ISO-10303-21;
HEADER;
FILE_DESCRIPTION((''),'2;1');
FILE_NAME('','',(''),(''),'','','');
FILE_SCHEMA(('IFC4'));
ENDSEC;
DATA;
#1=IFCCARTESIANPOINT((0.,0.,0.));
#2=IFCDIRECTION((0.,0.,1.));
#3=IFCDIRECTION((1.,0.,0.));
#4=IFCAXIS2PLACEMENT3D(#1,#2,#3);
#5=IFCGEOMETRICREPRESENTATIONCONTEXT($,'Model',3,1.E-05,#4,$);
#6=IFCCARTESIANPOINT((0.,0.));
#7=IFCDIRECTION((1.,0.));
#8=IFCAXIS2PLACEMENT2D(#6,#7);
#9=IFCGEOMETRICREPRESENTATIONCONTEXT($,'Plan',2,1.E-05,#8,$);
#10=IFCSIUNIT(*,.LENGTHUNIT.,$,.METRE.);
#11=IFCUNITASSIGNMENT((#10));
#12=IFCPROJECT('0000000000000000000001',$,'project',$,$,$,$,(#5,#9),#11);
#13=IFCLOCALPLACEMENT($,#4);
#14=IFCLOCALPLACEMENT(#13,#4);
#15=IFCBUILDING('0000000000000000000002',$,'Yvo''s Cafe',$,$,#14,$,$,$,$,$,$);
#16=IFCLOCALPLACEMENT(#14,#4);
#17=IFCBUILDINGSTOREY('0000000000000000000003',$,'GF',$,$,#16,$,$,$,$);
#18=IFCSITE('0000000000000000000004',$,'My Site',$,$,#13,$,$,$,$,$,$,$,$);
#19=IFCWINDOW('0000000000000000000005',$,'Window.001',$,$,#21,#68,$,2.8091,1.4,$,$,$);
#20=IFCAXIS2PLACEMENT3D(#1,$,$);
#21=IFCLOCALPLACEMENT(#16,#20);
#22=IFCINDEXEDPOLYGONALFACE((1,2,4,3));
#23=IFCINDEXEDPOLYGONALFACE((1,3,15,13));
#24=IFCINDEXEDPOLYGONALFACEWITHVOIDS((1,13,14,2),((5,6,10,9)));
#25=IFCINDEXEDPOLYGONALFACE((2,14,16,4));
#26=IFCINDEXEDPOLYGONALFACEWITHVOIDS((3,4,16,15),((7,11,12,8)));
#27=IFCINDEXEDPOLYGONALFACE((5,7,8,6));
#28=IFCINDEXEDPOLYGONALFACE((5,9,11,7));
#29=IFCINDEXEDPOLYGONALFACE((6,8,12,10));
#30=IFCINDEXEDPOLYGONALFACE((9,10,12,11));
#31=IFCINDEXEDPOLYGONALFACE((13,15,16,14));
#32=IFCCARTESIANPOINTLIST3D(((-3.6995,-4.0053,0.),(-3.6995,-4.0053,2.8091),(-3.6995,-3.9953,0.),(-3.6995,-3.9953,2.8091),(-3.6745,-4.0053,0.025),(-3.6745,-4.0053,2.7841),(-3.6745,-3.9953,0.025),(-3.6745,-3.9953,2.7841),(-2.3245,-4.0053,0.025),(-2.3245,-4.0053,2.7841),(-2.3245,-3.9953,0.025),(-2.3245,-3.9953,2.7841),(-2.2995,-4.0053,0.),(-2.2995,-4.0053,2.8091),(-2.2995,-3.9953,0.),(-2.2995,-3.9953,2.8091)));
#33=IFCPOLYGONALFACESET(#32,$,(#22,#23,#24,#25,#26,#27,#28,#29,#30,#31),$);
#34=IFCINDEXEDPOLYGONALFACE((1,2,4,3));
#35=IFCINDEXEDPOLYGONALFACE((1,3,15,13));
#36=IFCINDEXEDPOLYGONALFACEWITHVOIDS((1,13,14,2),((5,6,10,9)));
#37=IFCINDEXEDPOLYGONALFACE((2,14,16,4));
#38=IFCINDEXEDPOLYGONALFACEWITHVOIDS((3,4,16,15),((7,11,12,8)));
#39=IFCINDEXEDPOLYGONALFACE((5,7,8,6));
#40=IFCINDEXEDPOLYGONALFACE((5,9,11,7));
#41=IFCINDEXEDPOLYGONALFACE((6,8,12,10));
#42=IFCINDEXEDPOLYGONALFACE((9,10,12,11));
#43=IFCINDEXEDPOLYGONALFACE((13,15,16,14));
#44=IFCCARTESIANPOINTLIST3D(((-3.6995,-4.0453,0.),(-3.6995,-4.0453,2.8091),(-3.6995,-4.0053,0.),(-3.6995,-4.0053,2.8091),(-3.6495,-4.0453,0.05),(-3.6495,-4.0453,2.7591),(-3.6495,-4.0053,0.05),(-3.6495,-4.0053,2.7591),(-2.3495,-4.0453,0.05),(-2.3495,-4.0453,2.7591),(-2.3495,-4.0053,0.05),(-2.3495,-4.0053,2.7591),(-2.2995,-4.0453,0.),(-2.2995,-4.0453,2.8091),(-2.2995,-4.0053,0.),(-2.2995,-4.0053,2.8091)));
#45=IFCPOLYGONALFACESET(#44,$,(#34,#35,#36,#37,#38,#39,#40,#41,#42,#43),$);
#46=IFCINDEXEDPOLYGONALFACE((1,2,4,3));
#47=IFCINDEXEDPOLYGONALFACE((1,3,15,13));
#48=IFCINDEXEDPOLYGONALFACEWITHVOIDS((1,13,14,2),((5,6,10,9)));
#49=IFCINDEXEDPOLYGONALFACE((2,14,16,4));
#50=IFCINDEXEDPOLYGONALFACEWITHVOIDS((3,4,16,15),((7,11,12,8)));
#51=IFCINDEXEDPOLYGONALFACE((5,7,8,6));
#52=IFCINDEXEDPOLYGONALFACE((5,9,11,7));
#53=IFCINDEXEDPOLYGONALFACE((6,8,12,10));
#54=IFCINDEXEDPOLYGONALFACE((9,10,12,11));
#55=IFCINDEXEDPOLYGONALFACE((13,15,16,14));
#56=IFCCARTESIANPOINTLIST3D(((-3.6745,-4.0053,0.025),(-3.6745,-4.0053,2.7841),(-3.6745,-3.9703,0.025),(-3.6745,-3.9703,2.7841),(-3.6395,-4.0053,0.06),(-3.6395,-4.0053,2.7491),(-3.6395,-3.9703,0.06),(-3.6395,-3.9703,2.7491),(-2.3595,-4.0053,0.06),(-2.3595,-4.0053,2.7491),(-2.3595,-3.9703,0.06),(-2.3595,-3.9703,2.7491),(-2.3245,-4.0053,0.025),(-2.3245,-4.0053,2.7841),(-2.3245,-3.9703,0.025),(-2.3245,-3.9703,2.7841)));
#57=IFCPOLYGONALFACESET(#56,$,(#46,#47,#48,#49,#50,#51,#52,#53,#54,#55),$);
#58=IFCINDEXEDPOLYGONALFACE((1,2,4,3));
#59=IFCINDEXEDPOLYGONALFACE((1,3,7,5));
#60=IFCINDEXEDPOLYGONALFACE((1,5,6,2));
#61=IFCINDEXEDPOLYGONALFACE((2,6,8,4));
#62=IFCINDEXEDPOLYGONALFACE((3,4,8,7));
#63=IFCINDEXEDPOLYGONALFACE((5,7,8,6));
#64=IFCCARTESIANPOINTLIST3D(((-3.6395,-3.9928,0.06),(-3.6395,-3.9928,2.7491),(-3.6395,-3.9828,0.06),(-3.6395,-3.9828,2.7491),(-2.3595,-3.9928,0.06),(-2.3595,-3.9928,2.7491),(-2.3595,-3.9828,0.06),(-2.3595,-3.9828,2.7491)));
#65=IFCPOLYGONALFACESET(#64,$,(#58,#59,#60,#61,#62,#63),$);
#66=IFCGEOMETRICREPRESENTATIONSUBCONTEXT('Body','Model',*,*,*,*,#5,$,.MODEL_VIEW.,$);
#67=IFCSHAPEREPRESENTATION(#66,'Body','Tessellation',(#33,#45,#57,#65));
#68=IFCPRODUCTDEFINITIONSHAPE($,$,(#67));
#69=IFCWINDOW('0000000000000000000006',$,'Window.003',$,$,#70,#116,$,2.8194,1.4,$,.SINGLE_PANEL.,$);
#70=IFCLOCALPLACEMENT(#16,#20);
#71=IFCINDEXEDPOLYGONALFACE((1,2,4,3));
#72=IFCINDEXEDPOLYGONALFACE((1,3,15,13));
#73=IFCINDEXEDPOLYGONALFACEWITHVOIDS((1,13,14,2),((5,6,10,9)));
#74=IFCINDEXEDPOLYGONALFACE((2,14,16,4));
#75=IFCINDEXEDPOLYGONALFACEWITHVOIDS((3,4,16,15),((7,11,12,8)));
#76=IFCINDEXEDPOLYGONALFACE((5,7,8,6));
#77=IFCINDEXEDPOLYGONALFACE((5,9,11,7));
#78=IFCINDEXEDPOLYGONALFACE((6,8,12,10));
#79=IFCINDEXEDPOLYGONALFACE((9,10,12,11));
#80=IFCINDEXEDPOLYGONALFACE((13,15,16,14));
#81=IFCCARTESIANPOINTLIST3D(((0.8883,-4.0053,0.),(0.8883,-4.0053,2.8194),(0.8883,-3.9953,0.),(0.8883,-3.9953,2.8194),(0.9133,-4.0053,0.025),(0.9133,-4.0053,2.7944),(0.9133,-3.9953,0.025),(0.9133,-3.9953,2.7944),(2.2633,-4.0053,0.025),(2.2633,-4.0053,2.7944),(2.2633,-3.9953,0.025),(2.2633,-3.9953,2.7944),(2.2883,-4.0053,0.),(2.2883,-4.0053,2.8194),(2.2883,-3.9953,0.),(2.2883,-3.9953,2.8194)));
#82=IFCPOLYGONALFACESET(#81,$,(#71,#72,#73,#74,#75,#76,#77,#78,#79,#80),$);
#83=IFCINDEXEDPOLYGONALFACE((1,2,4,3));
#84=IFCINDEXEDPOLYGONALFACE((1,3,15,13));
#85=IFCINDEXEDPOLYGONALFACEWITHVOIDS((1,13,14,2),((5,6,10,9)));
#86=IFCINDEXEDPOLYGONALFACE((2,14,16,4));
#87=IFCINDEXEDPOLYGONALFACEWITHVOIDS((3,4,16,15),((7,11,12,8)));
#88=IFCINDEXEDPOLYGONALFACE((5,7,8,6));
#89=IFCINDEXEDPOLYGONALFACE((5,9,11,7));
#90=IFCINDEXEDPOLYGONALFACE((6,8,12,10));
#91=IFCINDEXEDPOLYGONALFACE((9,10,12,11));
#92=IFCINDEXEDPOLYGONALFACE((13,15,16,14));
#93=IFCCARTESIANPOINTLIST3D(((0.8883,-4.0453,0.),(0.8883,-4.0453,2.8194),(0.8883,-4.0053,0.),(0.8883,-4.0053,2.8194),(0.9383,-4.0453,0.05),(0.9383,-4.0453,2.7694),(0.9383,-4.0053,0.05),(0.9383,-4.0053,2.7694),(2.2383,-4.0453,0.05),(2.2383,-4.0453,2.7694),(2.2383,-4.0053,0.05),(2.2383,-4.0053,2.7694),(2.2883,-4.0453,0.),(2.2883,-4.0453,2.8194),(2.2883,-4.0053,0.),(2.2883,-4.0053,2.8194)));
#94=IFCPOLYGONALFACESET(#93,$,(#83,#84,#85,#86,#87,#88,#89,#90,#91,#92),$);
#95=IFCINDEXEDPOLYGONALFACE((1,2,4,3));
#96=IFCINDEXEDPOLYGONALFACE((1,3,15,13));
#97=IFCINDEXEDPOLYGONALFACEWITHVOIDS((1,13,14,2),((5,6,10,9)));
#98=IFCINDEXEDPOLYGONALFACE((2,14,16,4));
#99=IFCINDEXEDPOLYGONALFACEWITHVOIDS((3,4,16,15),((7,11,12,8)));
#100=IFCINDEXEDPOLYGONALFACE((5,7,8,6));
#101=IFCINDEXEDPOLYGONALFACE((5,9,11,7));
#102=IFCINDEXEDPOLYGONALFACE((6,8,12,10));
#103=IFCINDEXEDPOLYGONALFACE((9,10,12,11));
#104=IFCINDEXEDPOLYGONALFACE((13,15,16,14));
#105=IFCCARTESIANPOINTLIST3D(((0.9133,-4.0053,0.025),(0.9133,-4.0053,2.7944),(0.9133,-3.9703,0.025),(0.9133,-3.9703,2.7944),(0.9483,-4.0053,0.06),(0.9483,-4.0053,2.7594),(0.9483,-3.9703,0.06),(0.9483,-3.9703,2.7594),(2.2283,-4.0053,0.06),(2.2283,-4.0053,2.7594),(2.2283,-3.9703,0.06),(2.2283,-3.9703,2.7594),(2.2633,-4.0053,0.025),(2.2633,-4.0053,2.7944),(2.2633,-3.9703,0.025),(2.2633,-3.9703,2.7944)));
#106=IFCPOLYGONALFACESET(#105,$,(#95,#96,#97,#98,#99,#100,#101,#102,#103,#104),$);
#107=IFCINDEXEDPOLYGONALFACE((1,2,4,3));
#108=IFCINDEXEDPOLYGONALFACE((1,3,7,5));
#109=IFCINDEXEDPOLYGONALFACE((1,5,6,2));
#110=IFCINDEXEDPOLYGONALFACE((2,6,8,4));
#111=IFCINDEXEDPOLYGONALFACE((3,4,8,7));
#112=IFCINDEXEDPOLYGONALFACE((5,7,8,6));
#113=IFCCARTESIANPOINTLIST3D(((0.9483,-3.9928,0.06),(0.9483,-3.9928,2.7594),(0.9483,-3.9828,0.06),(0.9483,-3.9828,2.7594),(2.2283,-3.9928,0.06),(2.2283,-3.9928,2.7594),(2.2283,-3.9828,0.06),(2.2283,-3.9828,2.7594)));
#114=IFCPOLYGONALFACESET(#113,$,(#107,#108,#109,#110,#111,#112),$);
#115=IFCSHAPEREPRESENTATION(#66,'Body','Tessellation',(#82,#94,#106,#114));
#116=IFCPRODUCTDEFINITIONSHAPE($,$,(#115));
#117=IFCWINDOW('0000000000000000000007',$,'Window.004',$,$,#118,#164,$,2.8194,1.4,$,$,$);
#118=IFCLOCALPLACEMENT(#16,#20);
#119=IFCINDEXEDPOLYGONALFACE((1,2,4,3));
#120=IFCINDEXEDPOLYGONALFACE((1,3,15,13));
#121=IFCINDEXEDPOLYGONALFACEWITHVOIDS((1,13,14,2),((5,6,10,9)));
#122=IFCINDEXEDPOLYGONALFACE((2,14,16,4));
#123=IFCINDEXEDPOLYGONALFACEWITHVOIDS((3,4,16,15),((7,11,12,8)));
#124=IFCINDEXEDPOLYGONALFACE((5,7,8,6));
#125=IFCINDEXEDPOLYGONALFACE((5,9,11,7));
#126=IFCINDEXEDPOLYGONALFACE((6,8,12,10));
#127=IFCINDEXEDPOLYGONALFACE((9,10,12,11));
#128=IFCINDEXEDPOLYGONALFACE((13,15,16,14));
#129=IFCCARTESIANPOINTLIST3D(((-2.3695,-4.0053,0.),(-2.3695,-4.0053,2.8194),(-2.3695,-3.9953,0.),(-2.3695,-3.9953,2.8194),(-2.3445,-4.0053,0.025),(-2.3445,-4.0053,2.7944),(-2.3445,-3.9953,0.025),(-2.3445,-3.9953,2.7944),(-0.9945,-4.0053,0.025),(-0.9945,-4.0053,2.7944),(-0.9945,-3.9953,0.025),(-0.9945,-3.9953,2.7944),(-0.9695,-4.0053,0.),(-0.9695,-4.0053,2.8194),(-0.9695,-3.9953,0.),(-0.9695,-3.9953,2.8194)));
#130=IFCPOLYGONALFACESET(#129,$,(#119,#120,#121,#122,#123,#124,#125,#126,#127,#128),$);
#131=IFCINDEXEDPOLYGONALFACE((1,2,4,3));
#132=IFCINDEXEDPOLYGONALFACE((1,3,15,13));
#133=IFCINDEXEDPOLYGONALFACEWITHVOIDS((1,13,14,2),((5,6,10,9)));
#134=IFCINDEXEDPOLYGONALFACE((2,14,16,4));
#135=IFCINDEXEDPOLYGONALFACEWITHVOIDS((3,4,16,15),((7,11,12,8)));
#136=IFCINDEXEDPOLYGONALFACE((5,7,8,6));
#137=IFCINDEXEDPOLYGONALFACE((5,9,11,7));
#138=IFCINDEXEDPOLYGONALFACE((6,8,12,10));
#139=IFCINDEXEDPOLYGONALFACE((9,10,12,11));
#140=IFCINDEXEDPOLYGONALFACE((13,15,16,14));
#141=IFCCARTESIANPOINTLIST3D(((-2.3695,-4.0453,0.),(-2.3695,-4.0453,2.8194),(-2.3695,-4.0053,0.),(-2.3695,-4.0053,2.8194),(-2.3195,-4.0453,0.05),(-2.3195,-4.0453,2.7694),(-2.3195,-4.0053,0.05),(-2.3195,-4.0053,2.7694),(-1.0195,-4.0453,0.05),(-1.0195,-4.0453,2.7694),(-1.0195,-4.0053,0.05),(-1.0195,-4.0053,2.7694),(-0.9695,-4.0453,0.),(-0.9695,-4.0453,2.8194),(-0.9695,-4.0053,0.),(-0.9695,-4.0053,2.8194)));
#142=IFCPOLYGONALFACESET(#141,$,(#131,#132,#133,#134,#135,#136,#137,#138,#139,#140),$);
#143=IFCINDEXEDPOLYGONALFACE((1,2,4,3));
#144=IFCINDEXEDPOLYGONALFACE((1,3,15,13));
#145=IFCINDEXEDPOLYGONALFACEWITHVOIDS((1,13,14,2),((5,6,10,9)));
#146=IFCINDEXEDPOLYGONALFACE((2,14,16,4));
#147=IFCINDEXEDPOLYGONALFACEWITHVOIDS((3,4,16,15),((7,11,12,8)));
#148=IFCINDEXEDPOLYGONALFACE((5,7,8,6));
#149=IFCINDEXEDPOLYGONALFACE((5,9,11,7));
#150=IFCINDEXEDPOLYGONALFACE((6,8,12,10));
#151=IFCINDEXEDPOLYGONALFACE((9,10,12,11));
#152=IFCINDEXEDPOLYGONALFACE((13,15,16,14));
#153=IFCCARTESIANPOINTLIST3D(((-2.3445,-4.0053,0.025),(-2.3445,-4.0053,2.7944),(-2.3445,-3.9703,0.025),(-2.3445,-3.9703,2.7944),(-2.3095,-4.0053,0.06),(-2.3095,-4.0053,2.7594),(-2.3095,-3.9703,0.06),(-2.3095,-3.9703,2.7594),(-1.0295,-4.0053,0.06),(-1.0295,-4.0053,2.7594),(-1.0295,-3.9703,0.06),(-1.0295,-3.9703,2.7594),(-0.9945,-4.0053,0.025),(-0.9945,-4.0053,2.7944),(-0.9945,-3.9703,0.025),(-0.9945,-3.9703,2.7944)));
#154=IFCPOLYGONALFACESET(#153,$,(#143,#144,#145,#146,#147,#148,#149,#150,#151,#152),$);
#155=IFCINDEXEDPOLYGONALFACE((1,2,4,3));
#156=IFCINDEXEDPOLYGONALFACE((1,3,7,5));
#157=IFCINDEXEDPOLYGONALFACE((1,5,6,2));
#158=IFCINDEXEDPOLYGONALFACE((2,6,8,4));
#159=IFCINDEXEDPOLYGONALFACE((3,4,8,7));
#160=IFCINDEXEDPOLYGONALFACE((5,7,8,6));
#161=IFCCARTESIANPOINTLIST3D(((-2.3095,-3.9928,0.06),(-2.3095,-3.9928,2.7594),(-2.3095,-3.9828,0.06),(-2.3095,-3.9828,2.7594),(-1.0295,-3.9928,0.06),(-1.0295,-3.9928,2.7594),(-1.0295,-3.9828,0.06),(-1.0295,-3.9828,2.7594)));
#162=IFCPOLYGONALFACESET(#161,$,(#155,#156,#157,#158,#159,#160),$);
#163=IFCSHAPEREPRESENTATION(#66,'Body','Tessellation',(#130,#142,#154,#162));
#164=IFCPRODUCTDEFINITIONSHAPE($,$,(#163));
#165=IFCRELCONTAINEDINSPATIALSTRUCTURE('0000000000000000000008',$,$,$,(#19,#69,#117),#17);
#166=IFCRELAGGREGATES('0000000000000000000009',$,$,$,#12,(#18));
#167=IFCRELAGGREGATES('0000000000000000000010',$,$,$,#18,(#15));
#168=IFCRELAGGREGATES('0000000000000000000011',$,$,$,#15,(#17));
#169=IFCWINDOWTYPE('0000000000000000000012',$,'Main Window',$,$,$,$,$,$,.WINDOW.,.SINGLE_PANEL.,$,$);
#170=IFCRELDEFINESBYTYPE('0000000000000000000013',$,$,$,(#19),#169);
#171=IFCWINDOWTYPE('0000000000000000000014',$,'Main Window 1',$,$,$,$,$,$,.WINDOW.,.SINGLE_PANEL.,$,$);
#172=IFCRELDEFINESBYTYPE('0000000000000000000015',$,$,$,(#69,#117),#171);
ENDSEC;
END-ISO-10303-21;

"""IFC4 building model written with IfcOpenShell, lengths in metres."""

from ifc_helpers import new_model, entity, si_unit, frame, origin_with_axes, origin_2d_with_axis, place, context, subcontext, project, spatial, line, indexed_curve, outline, extrude, shape, source, transform, mapped, type_object, type_shapes, element, save


model = new_model("IFC4")

# Units and contexts
model_context = context("Model", 3, precision=1e-05, world=origin_with_axes())
plan_context = context("Plan", 2, precision=1e-05, world=origin_2d_with_axis())
body_context_1 = subcontext(model_context, "Body", "Model", "MODEL_VIEW")
body_context_2 = subcontext(plan_context, "Body", "Plan", "PLAN_VIEW")
ifc_project = project(units=[si_unit("LENGTHUNIT", "METRE")], contexts=[model_context, plan_context])

# Site, building, storey
site_placement = place(None, origin_with_axes())
site = spatial("IfcSite", under=ifc_project, at=site_placement, Name="My Site")
building_placement = place(site_placement, origin_with_axes())
building = spatial("IfcBuilding", under=site, at=building_placement, Name="Yvo's Cafe")
storey_placement = place(building_placement, origin_with_axes())
storey = spatial("IfcBuildingStorey", under=building, at=storey_placement, Name="GF")

# Windows
window_type_1 = type_object("IfcWindowType", Name="Main Window", PartitioningType="SINGLE_PANEL", PredefinedType="WINDOW")
shared_shape_1 = source(origin_with_axes(), body_context_1, "Body", "SweptSolid", [
    extrude(outline(indexed_curve([(0.0, 0.0), (1.4, 0.0), (1.4, 2.8091), (0.0, 2.8091)], segments=[line(1, 2, 3, 4, 1)]), holes=[indexed_curve([(0.025, 0.025), (1.375, 0.025), (1.375, 2.7841), (0.025, 2.7841)], segments=[line(1, 2, 3, 4, 1)])]), frame((0.0, 0.09, 0.0), z_axis=(0.0, -1.0, 0.0), x_axis=(1.0, 0.0, 0.0)), (0.0, 0.0, -1.0), 0.01),
    extrude(outline(indexed_curve([(0.0, 0.0), (1.4, 0.0), (1.4, 2.8091), (0.0, 2.8091)], segments=[line(1, 2, 3, 4, 1)]), holes=[indexed_curve([(0.05, 0.05), (1.35, 0.05), (1.35, 2.7591), (0.05, 2.7591)], segments=[line(1, 2, 3, 4, 1)])]), frame((0.0, 0.05, 0.0), z_axis=(0.0, -1.0, 0.0), x_axis=(1.0, 0.0, 0.0)), (0.0, 0.0, -1.0), 0.04),
    extrude(outline(indexed_curve([(0.0, 0.0), (1.35, 0.0), (1.35, 2.7591), (0.0, 2.7591)], segments=[line(1, 2, 3, 4, 1)]), holes=[indexed_curve([(0.035, 0.035), (1.315, 0.035), (1.315, 2.7241), (0.035, 2.7241)], segments=[line(1, 2, 3, 4, 1)])]), frame((0.025, 0.09, 0.025), z_axis=(0.0, -1.0, 0.0), x_axis=(1.0, 0.0, 0.0)), (0.0, 0.0, -1.0), 0.035),
    extrude(outline(indexed_curve([(0.035, 0.035), (1.315, 0.035), (1.315, 2.7241), (0.035, 2.7241)], segments=[line(1, 2, 3, 4, 1)])), frame((0.025, 0.1025, 0.025), z_axis=(0.0, -1.0, 0.0), x_axis=(1.0, 0.0, 0.0)), (0.0, 0.0, -1.0), 0.01),
])
shared_shape_2 = source(origin_with_axes(), body_context_2, "Body", "Curve2D", [
    entity("IfcIndexedPolyCurve", entity("IfcCartesianPointList2D", [[0.05, 0.05], [1.35, 0.05]])),
    entity("IfcIndexedPolyCurve", entity("IfcCartesianPointList2D", [[0.0, 0.1], [0.025, 0.1], [0.025, 0.09], [0.05, 0.09], [0.05, 0.05], [0.0, 0.05]]), [entity("IfcLineIndex", [1, 2, 3, 4, 5, 6, 1])]),
    entity("IfcIndexedPolyCurve", entity("IfcCartesianPointList2D", [[1.4, 0.1], [1.375, 0.1], [1.375, 0.09], [1.35, 0.09], [1.35, 0.05], [1.4, 0.05]]), [entity("IfcLineIndex", [1, 2, 3, 4, 5, 6, 1])]),
    entity("IfcIndexedPolyCurve", entity("IfcCartesianPointList2D", [[0.025, 0.09], [0.06, 0.09], [0.06, 0.125], [0.025, 0.125]]), [entity("IfcLineIndex", [1, 2, 3, 4, 1])]),
    entity("IfcIndexedPolyCurve", entity("IfcCartesianPointList2D", [[1.375, 0.09], [1.34, 0.09], [1.34, 0.125], [1.375, 0.125]]), [entity("IfcLineIndex", [1, 2, 3, 4, 1])]),
    entity("IfcIndexedPolyCurve", entity("IfcCartesianPointList2D", [[0.06, 0.09], [1.34, 0.09]])),
    entity("IfcIndexedPolyCurve", entity("IfcCartesianPointList2D", [[0.06, 0.125], [1.34, 0.125]])),
    entity("IfcIndexedPolyCurve", entity("IfcCartesianPointList2D", [[0.06, 0.1075], [1.34, 0.1075]])),
])
type_shapes(window_type_1, [shared_shape_1, shared_shape_2])
window_1_placement = place(storey_placement, frame((-3.6995, -4.0953, 0.0), z_axis=(0.0, 0.0, 1.0), x_axis=(1.0, 0.0, 0.0)))
element("IfcWindow", 1, at=window_1_placement, inside=storey, type_object=window_type_1, Name="Window.001", OverallHeight=2.8091, OverallWidth=1.4, shapes=[
    shape(body_context_1, "Body", "MappedRepresentation", [mapped(shared_shape_1, transform((0.0, 0.0, 0.0), x_axis=(1.0, 0.0, 0.0), y_axis=(0.0, 1.0, 0.0), z_axis=(0.0, 0.0, 1.0), scale=1.0))]),
    shape(body_context_2, "Body", "MappedRepresentation", [mapped(shared_shape_2, transform((0.0, 0.0, 0.0), x_axis=(1.0, 0.0, 0.0), y_axis=(0.0, 1.0, 0.0), z_axis=(0.0, 0.0, 1.0), scale=1.0))]),
])
window_type_2 = type_object("IfcWindowType", Name="Main Window 1", PartitioningType="SINGLE_PANEL", PredefinedType="WINDOW")
shared_shape_3 = source(origin_with_axes(), body_context_1, "Body", "SweptSolid", [
    extrude(outline(indexed_curve([(0.0, 0.0), (1.4, 0.0), (1.4, 2.8194), (0.0, 2.8194)], segments=[line(1, 2, 3, 4, 1)]), holes=[indexed_curve([(0.025, 0.025), (1.375, 0.025), (1.375, 2.7944), (0.025, 2.7944)], segments=[line(1, 2, 3, 4, 1)])]), frame((0.0, 0.09, 0.0), z_axis=(0.0, -1.0, 0.0), x_axis=(1.0, 0.0, 0.0)), (0.0, 0.0, -1.0), 0.01),
    extrude(outline(indexed_curve([(0.0, 0.0), (1.4, 0.0), (1.4, 2.8194), (0.0, 2.8194)], segments=[line(1, 2, 3, 4, 1)]), holes=[indexed_curve([(0.05, 0.05), (1.35, 0.05), (1.35, 2.7694), (0.05, 2.7694)], segments=[line(1, 2, 3, 4, 1)])]), frame((0.0, 0.05, 0.0), z_axis=(0.0, -1.0, 0.0), x_axis=(1.0, 0.0, 0.0)), (0.0, 0.0, -1.0), 0.04),
    extrude(outline(indexed_curve([(0.0, 0.0), (1.35, 0.0), (1.35, 2.7694), (0.0, 2.7694)], segments=[line(1, 2, 3, 4, 1)]), holes=[indexed_curve([(0.035, 0.035), (1.315, 0.035), (1.315, 2.7344), (0.035, 2.7344)], segments=[line(1, 2, 3, 4, 1)])]), frame((0.025, 0.09, 0.025), z_axis=(0.0, -1.0, 0.0), x_axis=(1.0, 0.0, 0.0)), (0.0, 0.0, -1.0), 0.035),
    extrude(outline(indexed_curve([(0.035, 0.035), (1.315, 0.035), (1.315, 2.7344), (0.035, 2.7344)], segments=[line(1, 2, 3, 4, 1)])), frame((0.025, 0.1025, 0.025), z_axis=(0.0, -1.0, 0.0), x_axis=(1.0, 0.0, 0.0)), (0.0, 0.0, -1.0), 0.01),
])
shared_shape_4 = source(origin_with_axes(), body_context_2, "Body", "Curve2D", [
    entity("IfcIndexedPolyCurve", entity("IfcCartesianPointList2D", [[0.05, 0.05], [1.35, 0.05]])),
    entity("IfcIndexedPolyCurve", entity("IfcCartesianPointList2D", [[0.0, 0.1], [0.025, 0.1], [0.025, 0.09], [0.05, 0.09], [0.05, 0.05], [0.0, 0.05]]), [entity("IfcLineIndex", [1, 2, 3, 4, 5, 6, 1])]),
    entity("IfcIndexedPolyCurve", entity("IfcCartesianPointList2D", [[1.4, 0.1], [1.375, 0.1], [1.375, 0.09], [1.35, 0.09], [1.35, 0.05], [1.4, 0.05]]), [entity("IfcLineIndex", [1, 2, 3, 4, 5, 6, 1])]),
    entity("IfcIndexedPolyCurve", entity("IfcCartesianPointList2D", [[0.025, 0.09], [0.06, 0.09], [0.06, 0.125], [0.025, 0.125]]), [entity("IfcLineIndex", [1, 2, 3, 4, 1])]),
    entity("IfcIndexedPolyCurve", entity("IfcCartesianPointList2D", [[1.375, 0.09], [1.34, 0.09], [1.34, 0.125], [1.375, 0.125]]), [entity("IfcLineIndex", [1, 2, 3, 4, 1])]),
    entity("IfcIndexedPolyCurve", entity("IfcCartesianPointList2D", [[0.06, 0.09], [1.34, 0.09]])),
    entity("IfcIndexedPolyCurve", entity("IfcCartesianPointList2D", [[0.06, 0.125], [1.34, 0.125]])),
    entity("IfcIndexedPolyCurve", entity("IfcCartesianPointList2D", [[0.06, 0.1075], [1.34, 0.1075]])),
])
type_shapes(window_type_2, [shared_shape_3, shared_shape_4])
window_2_placement = place(storey_placement, frame((0.8883, -4.0953, 0.0), z_axis=(0.0, 0.0, 1.0), x_axis=(1.0, 0.0, 0.0)))
element("IfcWindow", 2, at=window_2_placement, inside=storey, type_object=window_type_2, Name="Window.003", OverallHeight=2.8194, OverallWidth=1.4, PartitioningType="SINGLE_PANEL", shapes=[
    shape(body_context_1, "Body", "MappedRepresentation", [mapped(shared_shape_3, transform((0.0, 0.0, 0.0), x_axis=(1.0, 0.0, 0.0), y_axis=(0.0, 1.0, 0.0), z_axis=(0.0, 0.0, 1.0), scale=1.0))]),
    shape(body_context_2, "Body", "MappedRepresentation", [mapped(shared_shape_4, transform((0.0, 0.0, 0.0), x_axis=(1.0, 0.0, 0.0), y_axis=(0.0, 1.0, 0.0), z_axis=(0.0, 0.0, 1.0), scale=1.0))]),
])
window_3_placement = place(storey_placement, frame((-2.3695, -4.0953, 0.0), z_axis=(0.0, 0.0, 1.0), x_axis=(1.0, 0.0, 0.0)))
element("IfcWindow", 3, at=window_3_placement, inside=storey, type_object=window_type_2, Name="Window.004", OverallHeight=2.8194, OverallWidth=1.4, shapes=[
    shape(body_context_1, "Body", "MappedRepresentation", [mapped(shared_shape_3, transform((0.0, 0.0, 0.0), x_axis=(1.0, 0.0, 0.0), y_axis=(0.0, 1.0, 0.0), z_axis=(0.0, 0.0, 1.0), scale=1.0))]),
    shape(body_context_2, "Body", "MappedRepresentation", [mapped(shared_shape_4, transform((0.0, 0.0, 0.0), x_axis=(1.0, 0.0, 0.0), y_axis=(0.0, 1.0, 0.0), z_axis=(0.0, 0.0, 1.0), scale=1.0))]),
])

save(model, "model.ifc")
